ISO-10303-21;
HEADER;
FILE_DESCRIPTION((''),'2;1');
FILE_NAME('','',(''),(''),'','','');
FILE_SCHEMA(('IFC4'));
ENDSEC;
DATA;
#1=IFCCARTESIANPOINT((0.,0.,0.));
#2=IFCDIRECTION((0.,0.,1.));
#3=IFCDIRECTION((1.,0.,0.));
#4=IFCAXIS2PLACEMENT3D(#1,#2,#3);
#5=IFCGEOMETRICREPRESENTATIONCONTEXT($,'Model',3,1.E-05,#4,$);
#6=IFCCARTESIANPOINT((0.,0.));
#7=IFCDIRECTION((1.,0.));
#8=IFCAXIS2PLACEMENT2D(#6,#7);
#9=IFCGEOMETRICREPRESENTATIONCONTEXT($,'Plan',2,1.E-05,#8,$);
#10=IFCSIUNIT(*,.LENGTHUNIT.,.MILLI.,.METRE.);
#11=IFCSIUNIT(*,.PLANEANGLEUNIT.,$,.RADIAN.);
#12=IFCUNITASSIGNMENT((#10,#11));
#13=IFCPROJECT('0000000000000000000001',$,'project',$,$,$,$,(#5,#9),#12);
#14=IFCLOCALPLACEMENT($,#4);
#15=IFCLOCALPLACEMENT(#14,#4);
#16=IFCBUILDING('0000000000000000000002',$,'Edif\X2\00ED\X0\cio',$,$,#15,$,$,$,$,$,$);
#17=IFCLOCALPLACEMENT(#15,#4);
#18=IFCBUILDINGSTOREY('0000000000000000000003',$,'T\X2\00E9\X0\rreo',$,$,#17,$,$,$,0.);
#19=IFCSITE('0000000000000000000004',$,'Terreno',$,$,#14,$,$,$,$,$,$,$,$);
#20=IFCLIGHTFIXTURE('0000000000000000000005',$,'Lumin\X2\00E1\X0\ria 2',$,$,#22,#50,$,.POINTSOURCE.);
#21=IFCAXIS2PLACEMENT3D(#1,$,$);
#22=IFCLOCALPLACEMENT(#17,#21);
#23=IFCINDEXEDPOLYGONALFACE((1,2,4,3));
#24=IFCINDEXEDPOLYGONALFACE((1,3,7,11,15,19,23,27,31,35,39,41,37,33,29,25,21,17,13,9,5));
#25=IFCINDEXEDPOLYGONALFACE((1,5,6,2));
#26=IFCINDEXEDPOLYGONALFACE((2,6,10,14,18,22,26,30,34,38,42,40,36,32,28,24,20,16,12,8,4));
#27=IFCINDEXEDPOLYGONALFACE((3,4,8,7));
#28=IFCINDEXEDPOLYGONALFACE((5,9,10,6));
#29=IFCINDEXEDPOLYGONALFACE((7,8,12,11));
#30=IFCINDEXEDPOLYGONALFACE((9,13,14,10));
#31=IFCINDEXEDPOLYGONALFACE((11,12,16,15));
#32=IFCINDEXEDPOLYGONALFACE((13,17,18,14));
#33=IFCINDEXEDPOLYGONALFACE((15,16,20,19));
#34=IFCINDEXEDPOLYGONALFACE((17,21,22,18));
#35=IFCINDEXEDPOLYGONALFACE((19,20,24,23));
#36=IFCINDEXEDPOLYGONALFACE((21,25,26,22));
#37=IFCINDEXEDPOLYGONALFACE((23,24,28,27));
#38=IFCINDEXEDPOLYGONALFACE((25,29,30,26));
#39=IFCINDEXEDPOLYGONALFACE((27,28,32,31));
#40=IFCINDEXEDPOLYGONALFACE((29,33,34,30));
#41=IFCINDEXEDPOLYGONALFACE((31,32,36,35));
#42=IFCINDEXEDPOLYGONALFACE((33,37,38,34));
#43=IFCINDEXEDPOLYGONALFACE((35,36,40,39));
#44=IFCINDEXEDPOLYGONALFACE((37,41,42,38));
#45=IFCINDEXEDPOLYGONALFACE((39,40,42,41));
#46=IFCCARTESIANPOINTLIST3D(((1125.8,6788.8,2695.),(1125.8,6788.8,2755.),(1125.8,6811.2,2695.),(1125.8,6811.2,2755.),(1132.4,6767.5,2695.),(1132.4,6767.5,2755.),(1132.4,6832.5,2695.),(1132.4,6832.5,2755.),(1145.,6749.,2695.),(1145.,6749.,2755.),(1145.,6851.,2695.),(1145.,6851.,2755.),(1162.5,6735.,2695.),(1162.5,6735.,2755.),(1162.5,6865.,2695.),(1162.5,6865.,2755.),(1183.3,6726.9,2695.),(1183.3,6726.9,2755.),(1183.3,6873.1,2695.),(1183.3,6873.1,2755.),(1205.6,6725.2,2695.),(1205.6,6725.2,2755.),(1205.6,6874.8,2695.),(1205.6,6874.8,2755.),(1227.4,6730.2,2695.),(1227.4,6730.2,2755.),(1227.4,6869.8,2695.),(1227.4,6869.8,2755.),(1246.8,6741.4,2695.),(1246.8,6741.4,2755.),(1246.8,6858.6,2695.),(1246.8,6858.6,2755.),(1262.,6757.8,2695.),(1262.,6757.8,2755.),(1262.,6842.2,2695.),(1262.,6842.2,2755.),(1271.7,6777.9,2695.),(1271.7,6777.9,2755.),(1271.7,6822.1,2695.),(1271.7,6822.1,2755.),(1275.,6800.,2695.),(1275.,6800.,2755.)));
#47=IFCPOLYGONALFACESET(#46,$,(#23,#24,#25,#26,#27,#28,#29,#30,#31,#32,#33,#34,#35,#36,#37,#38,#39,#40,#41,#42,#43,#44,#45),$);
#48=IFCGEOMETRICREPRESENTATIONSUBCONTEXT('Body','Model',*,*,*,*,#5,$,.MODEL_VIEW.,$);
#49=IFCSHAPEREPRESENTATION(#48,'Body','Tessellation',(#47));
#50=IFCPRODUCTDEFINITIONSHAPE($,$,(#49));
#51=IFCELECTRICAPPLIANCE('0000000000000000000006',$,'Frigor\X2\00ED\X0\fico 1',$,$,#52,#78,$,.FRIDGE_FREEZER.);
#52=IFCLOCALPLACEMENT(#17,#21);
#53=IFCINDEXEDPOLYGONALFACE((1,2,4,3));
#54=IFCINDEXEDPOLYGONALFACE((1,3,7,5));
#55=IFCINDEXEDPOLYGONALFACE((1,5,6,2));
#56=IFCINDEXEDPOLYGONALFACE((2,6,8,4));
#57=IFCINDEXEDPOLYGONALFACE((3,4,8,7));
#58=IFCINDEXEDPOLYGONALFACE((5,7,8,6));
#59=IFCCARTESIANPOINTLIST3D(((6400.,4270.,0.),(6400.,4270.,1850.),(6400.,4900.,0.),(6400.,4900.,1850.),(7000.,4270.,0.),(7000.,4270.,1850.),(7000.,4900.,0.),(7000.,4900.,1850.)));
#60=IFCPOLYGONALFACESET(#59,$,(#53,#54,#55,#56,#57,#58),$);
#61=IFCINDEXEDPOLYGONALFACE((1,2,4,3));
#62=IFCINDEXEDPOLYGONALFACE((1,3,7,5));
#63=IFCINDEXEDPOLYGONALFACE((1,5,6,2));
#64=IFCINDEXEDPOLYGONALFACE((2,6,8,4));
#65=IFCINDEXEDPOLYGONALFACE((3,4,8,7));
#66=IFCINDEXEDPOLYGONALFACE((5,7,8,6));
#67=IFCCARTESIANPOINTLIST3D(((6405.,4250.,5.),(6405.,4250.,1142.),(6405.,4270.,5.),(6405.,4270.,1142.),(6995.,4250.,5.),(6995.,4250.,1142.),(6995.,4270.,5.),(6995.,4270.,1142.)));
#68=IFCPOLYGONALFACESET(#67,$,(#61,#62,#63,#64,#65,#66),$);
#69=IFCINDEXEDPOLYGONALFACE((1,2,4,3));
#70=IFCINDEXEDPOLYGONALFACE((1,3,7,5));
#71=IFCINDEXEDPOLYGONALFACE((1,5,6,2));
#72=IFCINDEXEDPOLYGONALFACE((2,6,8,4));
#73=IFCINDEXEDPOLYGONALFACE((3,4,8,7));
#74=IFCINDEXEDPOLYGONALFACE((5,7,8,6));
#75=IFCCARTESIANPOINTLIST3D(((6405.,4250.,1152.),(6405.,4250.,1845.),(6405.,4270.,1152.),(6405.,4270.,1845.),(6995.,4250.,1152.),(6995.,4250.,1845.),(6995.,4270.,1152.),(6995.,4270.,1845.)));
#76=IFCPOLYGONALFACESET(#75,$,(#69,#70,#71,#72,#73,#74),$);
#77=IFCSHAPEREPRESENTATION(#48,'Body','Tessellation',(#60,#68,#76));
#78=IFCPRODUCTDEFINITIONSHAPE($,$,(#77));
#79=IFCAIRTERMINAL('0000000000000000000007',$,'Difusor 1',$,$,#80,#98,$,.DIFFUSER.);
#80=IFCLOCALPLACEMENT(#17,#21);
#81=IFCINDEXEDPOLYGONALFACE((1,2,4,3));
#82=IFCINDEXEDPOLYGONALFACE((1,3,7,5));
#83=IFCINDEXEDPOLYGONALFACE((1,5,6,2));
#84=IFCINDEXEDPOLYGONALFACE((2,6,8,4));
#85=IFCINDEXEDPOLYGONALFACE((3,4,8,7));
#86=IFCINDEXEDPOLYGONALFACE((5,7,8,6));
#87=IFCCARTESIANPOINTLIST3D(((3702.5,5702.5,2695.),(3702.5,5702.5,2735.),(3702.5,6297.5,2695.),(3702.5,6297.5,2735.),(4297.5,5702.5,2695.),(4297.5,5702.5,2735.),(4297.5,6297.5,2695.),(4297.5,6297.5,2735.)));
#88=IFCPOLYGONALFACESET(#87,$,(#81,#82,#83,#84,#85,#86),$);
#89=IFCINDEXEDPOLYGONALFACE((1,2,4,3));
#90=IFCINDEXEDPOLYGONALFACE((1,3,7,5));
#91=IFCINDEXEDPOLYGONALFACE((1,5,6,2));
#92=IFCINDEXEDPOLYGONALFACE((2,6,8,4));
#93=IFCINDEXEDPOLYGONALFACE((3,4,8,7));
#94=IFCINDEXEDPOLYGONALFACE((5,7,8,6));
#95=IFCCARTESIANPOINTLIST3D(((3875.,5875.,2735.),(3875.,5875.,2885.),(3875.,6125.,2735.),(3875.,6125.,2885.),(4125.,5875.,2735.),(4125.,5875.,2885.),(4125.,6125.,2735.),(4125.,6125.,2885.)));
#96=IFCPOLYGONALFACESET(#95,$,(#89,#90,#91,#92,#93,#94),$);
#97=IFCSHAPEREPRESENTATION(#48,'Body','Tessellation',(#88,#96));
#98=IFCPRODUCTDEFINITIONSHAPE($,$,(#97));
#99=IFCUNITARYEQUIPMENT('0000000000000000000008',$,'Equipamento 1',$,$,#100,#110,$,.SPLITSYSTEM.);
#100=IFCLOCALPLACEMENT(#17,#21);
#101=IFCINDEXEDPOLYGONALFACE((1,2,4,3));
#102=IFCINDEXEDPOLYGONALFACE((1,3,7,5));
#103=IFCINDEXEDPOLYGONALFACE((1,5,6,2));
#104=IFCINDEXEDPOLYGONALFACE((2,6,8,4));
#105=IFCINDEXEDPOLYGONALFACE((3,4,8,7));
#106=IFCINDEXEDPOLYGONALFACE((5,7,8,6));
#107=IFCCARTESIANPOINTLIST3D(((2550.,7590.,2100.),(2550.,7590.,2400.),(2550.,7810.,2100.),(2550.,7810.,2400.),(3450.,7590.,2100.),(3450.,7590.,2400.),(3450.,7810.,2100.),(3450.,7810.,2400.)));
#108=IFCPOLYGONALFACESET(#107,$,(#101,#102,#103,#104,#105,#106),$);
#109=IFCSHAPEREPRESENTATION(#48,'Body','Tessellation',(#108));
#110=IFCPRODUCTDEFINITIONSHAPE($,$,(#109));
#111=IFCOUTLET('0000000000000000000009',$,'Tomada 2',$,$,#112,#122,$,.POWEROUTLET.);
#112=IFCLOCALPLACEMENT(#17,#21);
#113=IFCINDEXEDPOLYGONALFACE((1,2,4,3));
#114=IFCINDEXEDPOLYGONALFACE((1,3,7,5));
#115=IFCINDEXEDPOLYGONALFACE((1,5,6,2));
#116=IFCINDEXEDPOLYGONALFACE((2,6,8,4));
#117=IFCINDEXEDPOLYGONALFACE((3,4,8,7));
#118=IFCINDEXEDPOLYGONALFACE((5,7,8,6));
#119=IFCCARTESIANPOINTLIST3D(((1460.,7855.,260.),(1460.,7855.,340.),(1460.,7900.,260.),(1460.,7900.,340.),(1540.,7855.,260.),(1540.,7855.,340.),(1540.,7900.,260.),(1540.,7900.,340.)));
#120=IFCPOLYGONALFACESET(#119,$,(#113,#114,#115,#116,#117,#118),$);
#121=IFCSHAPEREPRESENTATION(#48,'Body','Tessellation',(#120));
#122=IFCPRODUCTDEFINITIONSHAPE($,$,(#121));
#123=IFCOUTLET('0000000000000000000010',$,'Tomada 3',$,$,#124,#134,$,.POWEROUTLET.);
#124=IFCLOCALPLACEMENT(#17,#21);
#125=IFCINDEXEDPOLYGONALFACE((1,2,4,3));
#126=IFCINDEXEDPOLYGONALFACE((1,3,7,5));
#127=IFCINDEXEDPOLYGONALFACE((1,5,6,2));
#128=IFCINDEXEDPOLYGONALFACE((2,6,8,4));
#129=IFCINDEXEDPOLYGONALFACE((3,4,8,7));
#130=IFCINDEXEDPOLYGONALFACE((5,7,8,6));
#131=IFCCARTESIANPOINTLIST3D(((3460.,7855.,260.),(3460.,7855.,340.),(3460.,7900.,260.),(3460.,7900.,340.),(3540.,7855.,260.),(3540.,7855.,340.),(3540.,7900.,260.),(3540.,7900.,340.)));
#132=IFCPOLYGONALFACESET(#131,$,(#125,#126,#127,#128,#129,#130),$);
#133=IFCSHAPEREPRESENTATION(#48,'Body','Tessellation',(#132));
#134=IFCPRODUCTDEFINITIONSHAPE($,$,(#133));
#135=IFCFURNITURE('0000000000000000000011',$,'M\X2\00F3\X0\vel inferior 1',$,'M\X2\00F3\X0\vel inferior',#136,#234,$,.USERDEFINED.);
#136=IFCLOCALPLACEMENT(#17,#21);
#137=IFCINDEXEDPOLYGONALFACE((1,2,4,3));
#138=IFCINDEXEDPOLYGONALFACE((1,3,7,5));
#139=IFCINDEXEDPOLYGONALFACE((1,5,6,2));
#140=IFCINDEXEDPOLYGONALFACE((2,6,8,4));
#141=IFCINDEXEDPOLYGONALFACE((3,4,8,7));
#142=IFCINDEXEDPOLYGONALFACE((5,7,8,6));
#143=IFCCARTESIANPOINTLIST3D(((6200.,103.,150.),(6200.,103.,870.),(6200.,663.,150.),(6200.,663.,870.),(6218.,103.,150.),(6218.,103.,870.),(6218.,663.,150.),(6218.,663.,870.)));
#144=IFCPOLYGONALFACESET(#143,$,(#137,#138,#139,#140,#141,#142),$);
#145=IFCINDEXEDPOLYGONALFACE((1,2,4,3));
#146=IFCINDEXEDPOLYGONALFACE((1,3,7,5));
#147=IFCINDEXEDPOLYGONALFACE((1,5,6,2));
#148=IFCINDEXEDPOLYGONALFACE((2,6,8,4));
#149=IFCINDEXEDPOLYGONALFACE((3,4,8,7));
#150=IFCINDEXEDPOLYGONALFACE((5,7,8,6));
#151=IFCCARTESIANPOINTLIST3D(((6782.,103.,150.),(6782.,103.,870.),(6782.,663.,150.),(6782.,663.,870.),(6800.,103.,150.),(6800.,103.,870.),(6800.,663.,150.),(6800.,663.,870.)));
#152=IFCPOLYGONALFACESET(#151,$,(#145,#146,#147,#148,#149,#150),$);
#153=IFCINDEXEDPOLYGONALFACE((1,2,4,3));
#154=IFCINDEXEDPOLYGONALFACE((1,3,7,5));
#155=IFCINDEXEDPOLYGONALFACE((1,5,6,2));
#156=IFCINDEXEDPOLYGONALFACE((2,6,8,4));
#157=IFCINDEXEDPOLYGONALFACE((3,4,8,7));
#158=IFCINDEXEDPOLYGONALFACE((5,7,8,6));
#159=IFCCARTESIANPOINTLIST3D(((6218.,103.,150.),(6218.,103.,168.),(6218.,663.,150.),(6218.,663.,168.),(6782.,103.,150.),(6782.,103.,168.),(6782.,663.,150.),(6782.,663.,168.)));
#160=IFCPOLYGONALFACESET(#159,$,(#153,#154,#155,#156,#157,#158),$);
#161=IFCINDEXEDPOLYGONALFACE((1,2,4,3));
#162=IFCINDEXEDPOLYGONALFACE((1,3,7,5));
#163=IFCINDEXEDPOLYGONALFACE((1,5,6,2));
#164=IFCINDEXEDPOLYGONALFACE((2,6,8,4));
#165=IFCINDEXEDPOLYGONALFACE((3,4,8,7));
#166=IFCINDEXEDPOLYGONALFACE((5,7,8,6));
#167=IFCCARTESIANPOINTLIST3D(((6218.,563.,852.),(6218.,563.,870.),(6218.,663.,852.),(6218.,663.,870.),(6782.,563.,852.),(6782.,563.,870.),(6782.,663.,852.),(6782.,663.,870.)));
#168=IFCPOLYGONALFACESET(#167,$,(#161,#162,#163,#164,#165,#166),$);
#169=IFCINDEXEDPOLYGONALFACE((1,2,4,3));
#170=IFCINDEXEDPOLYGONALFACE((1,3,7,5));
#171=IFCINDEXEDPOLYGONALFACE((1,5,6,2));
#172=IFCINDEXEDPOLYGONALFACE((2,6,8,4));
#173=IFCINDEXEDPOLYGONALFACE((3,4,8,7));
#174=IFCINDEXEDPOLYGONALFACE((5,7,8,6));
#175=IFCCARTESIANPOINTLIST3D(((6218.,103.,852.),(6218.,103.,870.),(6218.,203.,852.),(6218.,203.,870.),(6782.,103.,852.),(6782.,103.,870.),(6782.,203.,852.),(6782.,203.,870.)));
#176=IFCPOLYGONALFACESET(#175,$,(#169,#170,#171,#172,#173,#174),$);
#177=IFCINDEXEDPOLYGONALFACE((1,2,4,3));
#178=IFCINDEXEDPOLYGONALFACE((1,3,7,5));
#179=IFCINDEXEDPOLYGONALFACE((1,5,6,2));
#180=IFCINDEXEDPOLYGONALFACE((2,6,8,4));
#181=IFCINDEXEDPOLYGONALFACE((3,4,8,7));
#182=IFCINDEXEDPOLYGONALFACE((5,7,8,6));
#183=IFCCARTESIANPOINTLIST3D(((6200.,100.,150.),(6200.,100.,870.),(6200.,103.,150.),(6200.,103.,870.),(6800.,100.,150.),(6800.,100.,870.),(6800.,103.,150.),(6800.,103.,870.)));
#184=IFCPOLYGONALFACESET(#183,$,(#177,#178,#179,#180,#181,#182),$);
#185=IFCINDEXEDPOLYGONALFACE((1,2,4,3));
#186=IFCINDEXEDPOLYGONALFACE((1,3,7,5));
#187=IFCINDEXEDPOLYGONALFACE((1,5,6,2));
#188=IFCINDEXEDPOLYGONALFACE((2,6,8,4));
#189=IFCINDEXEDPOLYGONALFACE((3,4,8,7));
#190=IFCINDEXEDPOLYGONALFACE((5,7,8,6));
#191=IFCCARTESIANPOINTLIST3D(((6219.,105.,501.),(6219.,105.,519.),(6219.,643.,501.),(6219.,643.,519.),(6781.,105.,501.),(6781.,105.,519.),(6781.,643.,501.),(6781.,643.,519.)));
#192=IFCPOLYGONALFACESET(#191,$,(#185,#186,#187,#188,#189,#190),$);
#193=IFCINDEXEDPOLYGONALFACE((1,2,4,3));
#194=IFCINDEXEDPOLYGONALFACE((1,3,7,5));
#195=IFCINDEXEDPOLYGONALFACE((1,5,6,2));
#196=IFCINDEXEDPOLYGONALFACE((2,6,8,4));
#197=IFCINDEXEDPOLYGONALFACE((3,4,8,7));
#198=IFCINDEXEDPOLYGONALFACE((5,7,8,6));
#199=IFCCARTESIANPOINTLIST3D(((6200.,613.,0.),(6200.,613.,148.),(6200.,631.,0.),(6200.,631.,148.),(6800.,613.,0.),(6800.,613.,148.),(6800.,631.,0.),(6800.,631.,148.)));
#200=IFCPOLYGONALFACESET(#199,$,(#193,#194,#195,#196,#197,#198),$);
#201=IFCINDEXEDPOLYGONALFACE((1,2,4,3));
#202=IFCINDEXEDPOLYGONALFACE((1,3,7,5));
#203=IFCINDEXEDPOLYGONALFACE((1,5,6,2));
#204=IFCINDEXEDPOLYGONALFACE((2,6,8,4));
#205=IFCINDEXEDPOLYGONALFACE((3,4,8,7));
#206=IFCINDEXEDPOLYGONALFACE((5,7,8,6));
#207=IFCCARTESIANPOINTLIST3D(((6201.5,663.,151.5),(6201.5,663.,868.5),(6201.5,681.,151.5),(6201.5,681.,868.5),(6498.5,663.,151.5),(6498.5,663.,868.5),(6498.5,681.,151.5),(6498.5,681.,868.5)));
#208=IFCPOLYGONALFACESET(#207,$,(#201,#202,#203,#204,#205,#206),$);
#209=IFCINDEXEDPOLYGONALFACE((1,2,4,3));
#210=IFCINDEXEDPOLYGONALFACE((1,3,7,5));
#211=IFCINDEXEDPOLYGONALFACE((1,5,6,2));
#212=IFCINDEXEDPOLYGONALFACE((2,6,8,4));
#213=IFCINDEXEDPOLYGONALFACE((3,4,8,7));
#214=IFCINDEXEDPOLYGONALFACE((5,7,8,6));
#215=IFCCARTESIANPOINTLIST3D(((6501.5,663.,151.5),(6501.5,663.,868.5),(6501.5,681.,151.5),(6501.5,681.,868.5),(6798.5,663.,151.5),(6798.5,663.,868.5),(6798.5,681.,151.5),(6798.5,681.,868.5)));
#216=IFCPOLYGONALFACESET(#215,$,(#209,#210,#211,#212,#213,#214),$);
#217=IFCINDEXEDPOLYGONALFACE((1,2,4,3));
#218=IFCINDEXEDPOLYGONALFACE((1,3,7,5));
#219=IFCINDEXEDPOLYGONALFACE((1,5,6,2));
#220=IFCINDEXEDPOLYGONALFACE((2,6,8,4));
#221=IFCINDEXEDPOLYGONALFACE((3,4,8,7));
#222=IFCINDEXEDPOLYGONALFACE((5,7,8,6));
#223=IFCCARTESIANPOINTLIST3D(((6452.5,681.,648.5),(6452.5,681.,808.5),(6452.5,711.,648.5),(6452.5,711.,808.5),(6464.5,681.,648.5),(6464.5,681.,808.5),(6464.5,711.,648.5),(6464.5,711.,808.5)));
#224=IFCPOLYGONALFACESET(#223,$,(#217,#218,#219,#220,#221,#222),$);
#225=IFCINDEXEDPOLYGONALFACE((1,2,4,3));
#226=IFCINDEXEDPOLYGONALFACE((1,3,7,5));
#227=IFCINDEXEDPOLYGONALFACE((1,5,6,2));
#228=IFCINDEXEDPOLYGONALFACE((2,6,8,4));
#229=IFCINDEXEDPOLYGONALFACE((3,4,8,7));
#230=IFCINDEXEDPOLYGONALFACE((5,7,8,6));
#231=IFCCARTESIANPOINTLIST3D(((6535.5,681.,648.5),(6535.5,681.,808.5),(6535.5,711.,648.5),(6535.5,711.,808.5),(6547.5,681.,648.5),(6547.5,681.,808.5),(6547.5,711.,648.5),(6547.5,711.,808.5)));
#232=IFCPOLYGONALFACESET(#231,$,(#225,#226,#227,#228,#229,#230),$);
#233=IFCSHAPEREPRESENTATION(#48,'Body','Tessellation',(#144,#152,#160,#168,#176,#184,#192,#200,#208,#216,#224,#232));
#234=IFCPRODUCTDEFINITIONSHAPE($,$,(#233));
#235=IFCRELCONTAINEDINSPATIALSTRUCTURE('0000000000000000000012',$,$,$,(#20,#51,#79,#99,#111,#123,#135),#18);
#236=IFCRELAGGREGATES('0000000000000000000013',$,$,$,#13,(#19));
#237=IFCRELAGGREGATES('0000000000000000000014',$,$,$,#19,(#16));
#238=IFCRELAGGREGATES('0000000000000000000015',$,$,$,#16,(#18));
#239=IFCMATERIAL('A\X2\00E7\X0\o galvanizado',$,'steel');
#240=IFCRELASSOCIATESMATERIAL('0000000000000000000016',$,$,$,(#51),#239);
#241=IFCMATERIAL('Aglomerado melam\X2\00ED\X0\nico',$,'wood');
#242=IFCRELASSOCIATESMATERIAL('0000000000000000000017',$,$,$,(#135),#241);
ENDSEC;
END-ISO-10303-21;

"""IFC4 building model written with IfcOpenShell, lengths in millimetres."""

from ifc_helpers import new_model, si_unit, frame, frame_2d, origin, origin_with_axes, origin_2d, origin_2d_with_axis, place, context, subcontext, project, spatial, rectangle, circle, extrude, material, element, save


model = new_model("IFC4")

# Units and contexts
model_context = context("Model", 3, precision=1e-05, world=origin_with_axes())
plan_context = context("Plan", 2, precision=1e-05, world=origin_2d_with_axis())
body_context = subcontext(model_context, "Body", "Model", "MODEL_VIEW")
ifc_project = project(units=[si_unit("LENGTHUNIT", "METRE", prefix="MILLI"), si_unit("PLANEANGLEUNIT", "RADIAN")], contexts=[model_context, plan_context])

# Site, building, storey
site_placement = place(None, origin_with_axes())
site = spatial("IfcSite", under=ifc_project, at=site_placement, Name="Terreno")
building_placement = place(site_placement, origin_with_axes())
building = spatial("IfcBuilding", under=site, at=building_placement, Name="Edifício")
storey_placement = place(building_placement, origin_with_axes())
storey = spatial("IfcBuildingStorey", under=building, at=storey_placement, Name="Térreo", Elevation=0.0)

# Light fixture
light_fixture_1_placement = place(storey_placement, frame((1200.0, 6800.0, 2695.0), z_axis=(0.0, 0.0, 1.0), x_axis=(1.0, 0.0, 0.0)))
element("IfcLightFixture", 1, at=light_fixture_1_placement, inside=storey, Name="Luminária 2", PredefinedType="POINTSOURCE", context=body_context, shape_type="SweptSolid", body=[
    extrude(circle(Radius=75.0, at=origin_2d()), origin(), (0.0, 0.0, 1.0), 60.0),
])

# Electric appliance
ifc_material_1 = material(Name="Aço galvanizado", Category="steel")
electric_appliance_placement = place(storey_placement, frame((6700.0, 4900.0, 0.0), z_axis=(0.0, 0.0, 1.0), x_axis=(-1.0, 0.0, 0.0)))
element("IfcElectricAppliance", 2, at=electric_appliance_placement, inside=storey, material=ifc_material_1, Name="Frigorífico 1", PredefinedType="FRIDGE_FREEZER", context=body_context, shape_type="SweptSolid", body=[
    extrude(rectangle(XDim=600.0, YDim=630.0, at=frame_2d((0.0, 315.0))), origin(), (0.0, 0.0, 1.0), 1850.0),
    extrude(rectangle(XDim=590.0, YDim=20.0, at=frame_2d((0.0, 640.0))), frame((0.0, 0.0, 5.0)), (0.0, 0.0, 1.0), 1137.0),
    extrude(rectangle(XDim=590.0, YDim=20.0, at=frame_2d((0.0, 640.0))), frame((0.0, 0.0, 1152.0)), (0.0, 0.0, 1.0), 693.0),
])

# Air terminal
air_terminal_placement = place(storey_placement, frame((4000.0, 6000.0, 2695.0), z_axis=(0.0, 0.0, 1.0), x_axis=(1.0, 0.0, 0.0)))
element("IfcAirTerminal", 3, at=air_terminal_placement, inside=storey, Name="Difusor 1", PredefinedType="DIFFUSER", context=body_context, shape_type="SweptSolid", body=[
    extrude(rectangle(XDim=595.0, YDim=595.0, at=origin_2d()), origin(), (0.0, 0.0, 1.0), 40.0),
    extrude(rectangle(XDim=250.0, YDim=250.0, at=origin_2d()), frame((0.0, 0.0, 40.0)), (0.0, 0.0, 1.0), 150.0),
])

# Unitary equipment
unitary_equipment_placement = place(storey_placement, frame((3000.0, 7700.0, 2100.0), z_axis=(0.0, 0.0, 1.0), x_axis=(-1.0, 0.0, 0.0)))
element("IfcUnitaryEquipment", 4, at=unitary_equipment_placement, inside=storey, Name="Equipamento 1", PredefinedType="SPLITSYSTEM", context=body_context, shape_type="SweptSolid", body=[
    extrude(rectangle(XDim=900.0, YDim=220.0, at=origin_2d()), origin(), (0.0, 0.0, 1.0), 300.0),
])

# Outlets
for number, where, z_axis, x_axis, name in (
    (5, (1500.0, 7900.0, 0.0), (0.0, 0.0, 1.0), (-1.0, 0.0, 0.0), "Tomada 2"),
    (6, (3500.0, 7900.0, 0.0), (0.0, 0.0, 1.0), (-1.0, 0.0, 0.0), "Tomada 3"),
):
    element("IfcOutlet", number, at=place(storey_placement, frame(where, z_axis=z_axis, x_axis=x_axis)), inside=storey, Name=name, PredefinedType="POWEROUTLET", context=body_context, shape_type="SweptSolid", body=[
        extrude(rectangle(XDim=80.0, YDim=45.0, at=frame_2d((0.0, 22.5))), frame((0.0, 0.0, 260.0)), (0.0, 0.0, 1.0), 80.0),
    ])

# Furniture
ifc_material_2 = material(Name="Aglomerado melamínico", Category="wood")
furniture_1_placement = place(storey_placement, frame((6200.0, 100.0, 0.0), z_axis=(0.0, 0.0, 1.0), x_axis=(1.0, 0.0, 0.0)))
element("IfcFurniture", 7, at=furniture_1_placement, inside=storey, material=ifc_material_2, Name="Móvel inferior 1", ObjectType="Móvel inferior", PredefinedType="USERDEFINED", context=body_context, shape_type="SweptSolid", body=[
    extrude(rectangle(XDim=18.0, YDim=560.0, at=frame_2d((9.0, 283.0))), frame((0.0, 0.0, 150.0)), (0.0, 0.0, 1.0), 720.0),
    extrude(rectangle(XDim=18.0, YDim=560.0, at=frame_2d((591.0, 283.0))), frame((0.0, 0.0, 150.0)), (0.0, 0.0, 1.0), 720.0),
    extrude(rectangle(XDim=564.0, YDim=560.0, at=frame_2d((300.0, 283.0))), frame((0.0, 0.0, 150.0)), (0.0, 0.0, 1.0), 18.0),
    extrude(rectangle(XDim=564.0, YDim=100.0, at=frame_2d((300.0, 513.0))), frame((0.0, 0.0, 852.0)), (0.0, 0.0, 1.0), 18.0),
    extrude(rectangle(XDim=564.0, YDim=100.0, at=frame_2d((300.0, 53.0))), frame((0.0, 0.0, 852.0)), (0.0, 0.0, 1.0), 18.0),
    extrude(rectangle(XDim=600.0, YDim=3.0, at=frame_2d((300.0, 1.5))), frame((0.0, 0.0, 150.0)), (0.0, 0.0, 1.0), 720.0),
    extrude(rectangle(XDim=562.0, YDim=538.0, at=frame_2d((300.0, 274.0))), frame((0.0, 0.0, 501.0)), (0.0, 0.0, 1.0), 18.0),
    extrude(rectangle(XDim=600.0, YDim=18.0, at=frame_2d((300.0, 522.0))), origin(), (0.0, 0.0, 1.0), 148.0),
    extrude(rectangle(XDim=297.0, YDim=18.0, at=frame_2d((150.0, 572.0))), frame((0.0, 0.0, 151.5)), (0.0, 0.0, 1.0), 717.0),
    extrude(rectangle(XDim=297.0, YDim=18.0, at=frame_2d((450.0, 572.0))), frame((0.0, 0.0, 151.5)), (0.0, 0.0, 1.0), 717.0),
    extrude(rectangle(XDim=12.0, YDim=30.0, at=frame_2d((258.5, 596.0))), frame((0.0, 0.0, 648.5)), (0.0, 0.0, 1.0), 160.0),
    extrude(rectangle(XDim=12.0, YDim=30.0, at=frame_2d((341.5, 596.0))), frame((0.0, 0.0, 648.5)), (0.0, 0.0, 1.0), 160.0),
])

save(model, "model.ifc")
